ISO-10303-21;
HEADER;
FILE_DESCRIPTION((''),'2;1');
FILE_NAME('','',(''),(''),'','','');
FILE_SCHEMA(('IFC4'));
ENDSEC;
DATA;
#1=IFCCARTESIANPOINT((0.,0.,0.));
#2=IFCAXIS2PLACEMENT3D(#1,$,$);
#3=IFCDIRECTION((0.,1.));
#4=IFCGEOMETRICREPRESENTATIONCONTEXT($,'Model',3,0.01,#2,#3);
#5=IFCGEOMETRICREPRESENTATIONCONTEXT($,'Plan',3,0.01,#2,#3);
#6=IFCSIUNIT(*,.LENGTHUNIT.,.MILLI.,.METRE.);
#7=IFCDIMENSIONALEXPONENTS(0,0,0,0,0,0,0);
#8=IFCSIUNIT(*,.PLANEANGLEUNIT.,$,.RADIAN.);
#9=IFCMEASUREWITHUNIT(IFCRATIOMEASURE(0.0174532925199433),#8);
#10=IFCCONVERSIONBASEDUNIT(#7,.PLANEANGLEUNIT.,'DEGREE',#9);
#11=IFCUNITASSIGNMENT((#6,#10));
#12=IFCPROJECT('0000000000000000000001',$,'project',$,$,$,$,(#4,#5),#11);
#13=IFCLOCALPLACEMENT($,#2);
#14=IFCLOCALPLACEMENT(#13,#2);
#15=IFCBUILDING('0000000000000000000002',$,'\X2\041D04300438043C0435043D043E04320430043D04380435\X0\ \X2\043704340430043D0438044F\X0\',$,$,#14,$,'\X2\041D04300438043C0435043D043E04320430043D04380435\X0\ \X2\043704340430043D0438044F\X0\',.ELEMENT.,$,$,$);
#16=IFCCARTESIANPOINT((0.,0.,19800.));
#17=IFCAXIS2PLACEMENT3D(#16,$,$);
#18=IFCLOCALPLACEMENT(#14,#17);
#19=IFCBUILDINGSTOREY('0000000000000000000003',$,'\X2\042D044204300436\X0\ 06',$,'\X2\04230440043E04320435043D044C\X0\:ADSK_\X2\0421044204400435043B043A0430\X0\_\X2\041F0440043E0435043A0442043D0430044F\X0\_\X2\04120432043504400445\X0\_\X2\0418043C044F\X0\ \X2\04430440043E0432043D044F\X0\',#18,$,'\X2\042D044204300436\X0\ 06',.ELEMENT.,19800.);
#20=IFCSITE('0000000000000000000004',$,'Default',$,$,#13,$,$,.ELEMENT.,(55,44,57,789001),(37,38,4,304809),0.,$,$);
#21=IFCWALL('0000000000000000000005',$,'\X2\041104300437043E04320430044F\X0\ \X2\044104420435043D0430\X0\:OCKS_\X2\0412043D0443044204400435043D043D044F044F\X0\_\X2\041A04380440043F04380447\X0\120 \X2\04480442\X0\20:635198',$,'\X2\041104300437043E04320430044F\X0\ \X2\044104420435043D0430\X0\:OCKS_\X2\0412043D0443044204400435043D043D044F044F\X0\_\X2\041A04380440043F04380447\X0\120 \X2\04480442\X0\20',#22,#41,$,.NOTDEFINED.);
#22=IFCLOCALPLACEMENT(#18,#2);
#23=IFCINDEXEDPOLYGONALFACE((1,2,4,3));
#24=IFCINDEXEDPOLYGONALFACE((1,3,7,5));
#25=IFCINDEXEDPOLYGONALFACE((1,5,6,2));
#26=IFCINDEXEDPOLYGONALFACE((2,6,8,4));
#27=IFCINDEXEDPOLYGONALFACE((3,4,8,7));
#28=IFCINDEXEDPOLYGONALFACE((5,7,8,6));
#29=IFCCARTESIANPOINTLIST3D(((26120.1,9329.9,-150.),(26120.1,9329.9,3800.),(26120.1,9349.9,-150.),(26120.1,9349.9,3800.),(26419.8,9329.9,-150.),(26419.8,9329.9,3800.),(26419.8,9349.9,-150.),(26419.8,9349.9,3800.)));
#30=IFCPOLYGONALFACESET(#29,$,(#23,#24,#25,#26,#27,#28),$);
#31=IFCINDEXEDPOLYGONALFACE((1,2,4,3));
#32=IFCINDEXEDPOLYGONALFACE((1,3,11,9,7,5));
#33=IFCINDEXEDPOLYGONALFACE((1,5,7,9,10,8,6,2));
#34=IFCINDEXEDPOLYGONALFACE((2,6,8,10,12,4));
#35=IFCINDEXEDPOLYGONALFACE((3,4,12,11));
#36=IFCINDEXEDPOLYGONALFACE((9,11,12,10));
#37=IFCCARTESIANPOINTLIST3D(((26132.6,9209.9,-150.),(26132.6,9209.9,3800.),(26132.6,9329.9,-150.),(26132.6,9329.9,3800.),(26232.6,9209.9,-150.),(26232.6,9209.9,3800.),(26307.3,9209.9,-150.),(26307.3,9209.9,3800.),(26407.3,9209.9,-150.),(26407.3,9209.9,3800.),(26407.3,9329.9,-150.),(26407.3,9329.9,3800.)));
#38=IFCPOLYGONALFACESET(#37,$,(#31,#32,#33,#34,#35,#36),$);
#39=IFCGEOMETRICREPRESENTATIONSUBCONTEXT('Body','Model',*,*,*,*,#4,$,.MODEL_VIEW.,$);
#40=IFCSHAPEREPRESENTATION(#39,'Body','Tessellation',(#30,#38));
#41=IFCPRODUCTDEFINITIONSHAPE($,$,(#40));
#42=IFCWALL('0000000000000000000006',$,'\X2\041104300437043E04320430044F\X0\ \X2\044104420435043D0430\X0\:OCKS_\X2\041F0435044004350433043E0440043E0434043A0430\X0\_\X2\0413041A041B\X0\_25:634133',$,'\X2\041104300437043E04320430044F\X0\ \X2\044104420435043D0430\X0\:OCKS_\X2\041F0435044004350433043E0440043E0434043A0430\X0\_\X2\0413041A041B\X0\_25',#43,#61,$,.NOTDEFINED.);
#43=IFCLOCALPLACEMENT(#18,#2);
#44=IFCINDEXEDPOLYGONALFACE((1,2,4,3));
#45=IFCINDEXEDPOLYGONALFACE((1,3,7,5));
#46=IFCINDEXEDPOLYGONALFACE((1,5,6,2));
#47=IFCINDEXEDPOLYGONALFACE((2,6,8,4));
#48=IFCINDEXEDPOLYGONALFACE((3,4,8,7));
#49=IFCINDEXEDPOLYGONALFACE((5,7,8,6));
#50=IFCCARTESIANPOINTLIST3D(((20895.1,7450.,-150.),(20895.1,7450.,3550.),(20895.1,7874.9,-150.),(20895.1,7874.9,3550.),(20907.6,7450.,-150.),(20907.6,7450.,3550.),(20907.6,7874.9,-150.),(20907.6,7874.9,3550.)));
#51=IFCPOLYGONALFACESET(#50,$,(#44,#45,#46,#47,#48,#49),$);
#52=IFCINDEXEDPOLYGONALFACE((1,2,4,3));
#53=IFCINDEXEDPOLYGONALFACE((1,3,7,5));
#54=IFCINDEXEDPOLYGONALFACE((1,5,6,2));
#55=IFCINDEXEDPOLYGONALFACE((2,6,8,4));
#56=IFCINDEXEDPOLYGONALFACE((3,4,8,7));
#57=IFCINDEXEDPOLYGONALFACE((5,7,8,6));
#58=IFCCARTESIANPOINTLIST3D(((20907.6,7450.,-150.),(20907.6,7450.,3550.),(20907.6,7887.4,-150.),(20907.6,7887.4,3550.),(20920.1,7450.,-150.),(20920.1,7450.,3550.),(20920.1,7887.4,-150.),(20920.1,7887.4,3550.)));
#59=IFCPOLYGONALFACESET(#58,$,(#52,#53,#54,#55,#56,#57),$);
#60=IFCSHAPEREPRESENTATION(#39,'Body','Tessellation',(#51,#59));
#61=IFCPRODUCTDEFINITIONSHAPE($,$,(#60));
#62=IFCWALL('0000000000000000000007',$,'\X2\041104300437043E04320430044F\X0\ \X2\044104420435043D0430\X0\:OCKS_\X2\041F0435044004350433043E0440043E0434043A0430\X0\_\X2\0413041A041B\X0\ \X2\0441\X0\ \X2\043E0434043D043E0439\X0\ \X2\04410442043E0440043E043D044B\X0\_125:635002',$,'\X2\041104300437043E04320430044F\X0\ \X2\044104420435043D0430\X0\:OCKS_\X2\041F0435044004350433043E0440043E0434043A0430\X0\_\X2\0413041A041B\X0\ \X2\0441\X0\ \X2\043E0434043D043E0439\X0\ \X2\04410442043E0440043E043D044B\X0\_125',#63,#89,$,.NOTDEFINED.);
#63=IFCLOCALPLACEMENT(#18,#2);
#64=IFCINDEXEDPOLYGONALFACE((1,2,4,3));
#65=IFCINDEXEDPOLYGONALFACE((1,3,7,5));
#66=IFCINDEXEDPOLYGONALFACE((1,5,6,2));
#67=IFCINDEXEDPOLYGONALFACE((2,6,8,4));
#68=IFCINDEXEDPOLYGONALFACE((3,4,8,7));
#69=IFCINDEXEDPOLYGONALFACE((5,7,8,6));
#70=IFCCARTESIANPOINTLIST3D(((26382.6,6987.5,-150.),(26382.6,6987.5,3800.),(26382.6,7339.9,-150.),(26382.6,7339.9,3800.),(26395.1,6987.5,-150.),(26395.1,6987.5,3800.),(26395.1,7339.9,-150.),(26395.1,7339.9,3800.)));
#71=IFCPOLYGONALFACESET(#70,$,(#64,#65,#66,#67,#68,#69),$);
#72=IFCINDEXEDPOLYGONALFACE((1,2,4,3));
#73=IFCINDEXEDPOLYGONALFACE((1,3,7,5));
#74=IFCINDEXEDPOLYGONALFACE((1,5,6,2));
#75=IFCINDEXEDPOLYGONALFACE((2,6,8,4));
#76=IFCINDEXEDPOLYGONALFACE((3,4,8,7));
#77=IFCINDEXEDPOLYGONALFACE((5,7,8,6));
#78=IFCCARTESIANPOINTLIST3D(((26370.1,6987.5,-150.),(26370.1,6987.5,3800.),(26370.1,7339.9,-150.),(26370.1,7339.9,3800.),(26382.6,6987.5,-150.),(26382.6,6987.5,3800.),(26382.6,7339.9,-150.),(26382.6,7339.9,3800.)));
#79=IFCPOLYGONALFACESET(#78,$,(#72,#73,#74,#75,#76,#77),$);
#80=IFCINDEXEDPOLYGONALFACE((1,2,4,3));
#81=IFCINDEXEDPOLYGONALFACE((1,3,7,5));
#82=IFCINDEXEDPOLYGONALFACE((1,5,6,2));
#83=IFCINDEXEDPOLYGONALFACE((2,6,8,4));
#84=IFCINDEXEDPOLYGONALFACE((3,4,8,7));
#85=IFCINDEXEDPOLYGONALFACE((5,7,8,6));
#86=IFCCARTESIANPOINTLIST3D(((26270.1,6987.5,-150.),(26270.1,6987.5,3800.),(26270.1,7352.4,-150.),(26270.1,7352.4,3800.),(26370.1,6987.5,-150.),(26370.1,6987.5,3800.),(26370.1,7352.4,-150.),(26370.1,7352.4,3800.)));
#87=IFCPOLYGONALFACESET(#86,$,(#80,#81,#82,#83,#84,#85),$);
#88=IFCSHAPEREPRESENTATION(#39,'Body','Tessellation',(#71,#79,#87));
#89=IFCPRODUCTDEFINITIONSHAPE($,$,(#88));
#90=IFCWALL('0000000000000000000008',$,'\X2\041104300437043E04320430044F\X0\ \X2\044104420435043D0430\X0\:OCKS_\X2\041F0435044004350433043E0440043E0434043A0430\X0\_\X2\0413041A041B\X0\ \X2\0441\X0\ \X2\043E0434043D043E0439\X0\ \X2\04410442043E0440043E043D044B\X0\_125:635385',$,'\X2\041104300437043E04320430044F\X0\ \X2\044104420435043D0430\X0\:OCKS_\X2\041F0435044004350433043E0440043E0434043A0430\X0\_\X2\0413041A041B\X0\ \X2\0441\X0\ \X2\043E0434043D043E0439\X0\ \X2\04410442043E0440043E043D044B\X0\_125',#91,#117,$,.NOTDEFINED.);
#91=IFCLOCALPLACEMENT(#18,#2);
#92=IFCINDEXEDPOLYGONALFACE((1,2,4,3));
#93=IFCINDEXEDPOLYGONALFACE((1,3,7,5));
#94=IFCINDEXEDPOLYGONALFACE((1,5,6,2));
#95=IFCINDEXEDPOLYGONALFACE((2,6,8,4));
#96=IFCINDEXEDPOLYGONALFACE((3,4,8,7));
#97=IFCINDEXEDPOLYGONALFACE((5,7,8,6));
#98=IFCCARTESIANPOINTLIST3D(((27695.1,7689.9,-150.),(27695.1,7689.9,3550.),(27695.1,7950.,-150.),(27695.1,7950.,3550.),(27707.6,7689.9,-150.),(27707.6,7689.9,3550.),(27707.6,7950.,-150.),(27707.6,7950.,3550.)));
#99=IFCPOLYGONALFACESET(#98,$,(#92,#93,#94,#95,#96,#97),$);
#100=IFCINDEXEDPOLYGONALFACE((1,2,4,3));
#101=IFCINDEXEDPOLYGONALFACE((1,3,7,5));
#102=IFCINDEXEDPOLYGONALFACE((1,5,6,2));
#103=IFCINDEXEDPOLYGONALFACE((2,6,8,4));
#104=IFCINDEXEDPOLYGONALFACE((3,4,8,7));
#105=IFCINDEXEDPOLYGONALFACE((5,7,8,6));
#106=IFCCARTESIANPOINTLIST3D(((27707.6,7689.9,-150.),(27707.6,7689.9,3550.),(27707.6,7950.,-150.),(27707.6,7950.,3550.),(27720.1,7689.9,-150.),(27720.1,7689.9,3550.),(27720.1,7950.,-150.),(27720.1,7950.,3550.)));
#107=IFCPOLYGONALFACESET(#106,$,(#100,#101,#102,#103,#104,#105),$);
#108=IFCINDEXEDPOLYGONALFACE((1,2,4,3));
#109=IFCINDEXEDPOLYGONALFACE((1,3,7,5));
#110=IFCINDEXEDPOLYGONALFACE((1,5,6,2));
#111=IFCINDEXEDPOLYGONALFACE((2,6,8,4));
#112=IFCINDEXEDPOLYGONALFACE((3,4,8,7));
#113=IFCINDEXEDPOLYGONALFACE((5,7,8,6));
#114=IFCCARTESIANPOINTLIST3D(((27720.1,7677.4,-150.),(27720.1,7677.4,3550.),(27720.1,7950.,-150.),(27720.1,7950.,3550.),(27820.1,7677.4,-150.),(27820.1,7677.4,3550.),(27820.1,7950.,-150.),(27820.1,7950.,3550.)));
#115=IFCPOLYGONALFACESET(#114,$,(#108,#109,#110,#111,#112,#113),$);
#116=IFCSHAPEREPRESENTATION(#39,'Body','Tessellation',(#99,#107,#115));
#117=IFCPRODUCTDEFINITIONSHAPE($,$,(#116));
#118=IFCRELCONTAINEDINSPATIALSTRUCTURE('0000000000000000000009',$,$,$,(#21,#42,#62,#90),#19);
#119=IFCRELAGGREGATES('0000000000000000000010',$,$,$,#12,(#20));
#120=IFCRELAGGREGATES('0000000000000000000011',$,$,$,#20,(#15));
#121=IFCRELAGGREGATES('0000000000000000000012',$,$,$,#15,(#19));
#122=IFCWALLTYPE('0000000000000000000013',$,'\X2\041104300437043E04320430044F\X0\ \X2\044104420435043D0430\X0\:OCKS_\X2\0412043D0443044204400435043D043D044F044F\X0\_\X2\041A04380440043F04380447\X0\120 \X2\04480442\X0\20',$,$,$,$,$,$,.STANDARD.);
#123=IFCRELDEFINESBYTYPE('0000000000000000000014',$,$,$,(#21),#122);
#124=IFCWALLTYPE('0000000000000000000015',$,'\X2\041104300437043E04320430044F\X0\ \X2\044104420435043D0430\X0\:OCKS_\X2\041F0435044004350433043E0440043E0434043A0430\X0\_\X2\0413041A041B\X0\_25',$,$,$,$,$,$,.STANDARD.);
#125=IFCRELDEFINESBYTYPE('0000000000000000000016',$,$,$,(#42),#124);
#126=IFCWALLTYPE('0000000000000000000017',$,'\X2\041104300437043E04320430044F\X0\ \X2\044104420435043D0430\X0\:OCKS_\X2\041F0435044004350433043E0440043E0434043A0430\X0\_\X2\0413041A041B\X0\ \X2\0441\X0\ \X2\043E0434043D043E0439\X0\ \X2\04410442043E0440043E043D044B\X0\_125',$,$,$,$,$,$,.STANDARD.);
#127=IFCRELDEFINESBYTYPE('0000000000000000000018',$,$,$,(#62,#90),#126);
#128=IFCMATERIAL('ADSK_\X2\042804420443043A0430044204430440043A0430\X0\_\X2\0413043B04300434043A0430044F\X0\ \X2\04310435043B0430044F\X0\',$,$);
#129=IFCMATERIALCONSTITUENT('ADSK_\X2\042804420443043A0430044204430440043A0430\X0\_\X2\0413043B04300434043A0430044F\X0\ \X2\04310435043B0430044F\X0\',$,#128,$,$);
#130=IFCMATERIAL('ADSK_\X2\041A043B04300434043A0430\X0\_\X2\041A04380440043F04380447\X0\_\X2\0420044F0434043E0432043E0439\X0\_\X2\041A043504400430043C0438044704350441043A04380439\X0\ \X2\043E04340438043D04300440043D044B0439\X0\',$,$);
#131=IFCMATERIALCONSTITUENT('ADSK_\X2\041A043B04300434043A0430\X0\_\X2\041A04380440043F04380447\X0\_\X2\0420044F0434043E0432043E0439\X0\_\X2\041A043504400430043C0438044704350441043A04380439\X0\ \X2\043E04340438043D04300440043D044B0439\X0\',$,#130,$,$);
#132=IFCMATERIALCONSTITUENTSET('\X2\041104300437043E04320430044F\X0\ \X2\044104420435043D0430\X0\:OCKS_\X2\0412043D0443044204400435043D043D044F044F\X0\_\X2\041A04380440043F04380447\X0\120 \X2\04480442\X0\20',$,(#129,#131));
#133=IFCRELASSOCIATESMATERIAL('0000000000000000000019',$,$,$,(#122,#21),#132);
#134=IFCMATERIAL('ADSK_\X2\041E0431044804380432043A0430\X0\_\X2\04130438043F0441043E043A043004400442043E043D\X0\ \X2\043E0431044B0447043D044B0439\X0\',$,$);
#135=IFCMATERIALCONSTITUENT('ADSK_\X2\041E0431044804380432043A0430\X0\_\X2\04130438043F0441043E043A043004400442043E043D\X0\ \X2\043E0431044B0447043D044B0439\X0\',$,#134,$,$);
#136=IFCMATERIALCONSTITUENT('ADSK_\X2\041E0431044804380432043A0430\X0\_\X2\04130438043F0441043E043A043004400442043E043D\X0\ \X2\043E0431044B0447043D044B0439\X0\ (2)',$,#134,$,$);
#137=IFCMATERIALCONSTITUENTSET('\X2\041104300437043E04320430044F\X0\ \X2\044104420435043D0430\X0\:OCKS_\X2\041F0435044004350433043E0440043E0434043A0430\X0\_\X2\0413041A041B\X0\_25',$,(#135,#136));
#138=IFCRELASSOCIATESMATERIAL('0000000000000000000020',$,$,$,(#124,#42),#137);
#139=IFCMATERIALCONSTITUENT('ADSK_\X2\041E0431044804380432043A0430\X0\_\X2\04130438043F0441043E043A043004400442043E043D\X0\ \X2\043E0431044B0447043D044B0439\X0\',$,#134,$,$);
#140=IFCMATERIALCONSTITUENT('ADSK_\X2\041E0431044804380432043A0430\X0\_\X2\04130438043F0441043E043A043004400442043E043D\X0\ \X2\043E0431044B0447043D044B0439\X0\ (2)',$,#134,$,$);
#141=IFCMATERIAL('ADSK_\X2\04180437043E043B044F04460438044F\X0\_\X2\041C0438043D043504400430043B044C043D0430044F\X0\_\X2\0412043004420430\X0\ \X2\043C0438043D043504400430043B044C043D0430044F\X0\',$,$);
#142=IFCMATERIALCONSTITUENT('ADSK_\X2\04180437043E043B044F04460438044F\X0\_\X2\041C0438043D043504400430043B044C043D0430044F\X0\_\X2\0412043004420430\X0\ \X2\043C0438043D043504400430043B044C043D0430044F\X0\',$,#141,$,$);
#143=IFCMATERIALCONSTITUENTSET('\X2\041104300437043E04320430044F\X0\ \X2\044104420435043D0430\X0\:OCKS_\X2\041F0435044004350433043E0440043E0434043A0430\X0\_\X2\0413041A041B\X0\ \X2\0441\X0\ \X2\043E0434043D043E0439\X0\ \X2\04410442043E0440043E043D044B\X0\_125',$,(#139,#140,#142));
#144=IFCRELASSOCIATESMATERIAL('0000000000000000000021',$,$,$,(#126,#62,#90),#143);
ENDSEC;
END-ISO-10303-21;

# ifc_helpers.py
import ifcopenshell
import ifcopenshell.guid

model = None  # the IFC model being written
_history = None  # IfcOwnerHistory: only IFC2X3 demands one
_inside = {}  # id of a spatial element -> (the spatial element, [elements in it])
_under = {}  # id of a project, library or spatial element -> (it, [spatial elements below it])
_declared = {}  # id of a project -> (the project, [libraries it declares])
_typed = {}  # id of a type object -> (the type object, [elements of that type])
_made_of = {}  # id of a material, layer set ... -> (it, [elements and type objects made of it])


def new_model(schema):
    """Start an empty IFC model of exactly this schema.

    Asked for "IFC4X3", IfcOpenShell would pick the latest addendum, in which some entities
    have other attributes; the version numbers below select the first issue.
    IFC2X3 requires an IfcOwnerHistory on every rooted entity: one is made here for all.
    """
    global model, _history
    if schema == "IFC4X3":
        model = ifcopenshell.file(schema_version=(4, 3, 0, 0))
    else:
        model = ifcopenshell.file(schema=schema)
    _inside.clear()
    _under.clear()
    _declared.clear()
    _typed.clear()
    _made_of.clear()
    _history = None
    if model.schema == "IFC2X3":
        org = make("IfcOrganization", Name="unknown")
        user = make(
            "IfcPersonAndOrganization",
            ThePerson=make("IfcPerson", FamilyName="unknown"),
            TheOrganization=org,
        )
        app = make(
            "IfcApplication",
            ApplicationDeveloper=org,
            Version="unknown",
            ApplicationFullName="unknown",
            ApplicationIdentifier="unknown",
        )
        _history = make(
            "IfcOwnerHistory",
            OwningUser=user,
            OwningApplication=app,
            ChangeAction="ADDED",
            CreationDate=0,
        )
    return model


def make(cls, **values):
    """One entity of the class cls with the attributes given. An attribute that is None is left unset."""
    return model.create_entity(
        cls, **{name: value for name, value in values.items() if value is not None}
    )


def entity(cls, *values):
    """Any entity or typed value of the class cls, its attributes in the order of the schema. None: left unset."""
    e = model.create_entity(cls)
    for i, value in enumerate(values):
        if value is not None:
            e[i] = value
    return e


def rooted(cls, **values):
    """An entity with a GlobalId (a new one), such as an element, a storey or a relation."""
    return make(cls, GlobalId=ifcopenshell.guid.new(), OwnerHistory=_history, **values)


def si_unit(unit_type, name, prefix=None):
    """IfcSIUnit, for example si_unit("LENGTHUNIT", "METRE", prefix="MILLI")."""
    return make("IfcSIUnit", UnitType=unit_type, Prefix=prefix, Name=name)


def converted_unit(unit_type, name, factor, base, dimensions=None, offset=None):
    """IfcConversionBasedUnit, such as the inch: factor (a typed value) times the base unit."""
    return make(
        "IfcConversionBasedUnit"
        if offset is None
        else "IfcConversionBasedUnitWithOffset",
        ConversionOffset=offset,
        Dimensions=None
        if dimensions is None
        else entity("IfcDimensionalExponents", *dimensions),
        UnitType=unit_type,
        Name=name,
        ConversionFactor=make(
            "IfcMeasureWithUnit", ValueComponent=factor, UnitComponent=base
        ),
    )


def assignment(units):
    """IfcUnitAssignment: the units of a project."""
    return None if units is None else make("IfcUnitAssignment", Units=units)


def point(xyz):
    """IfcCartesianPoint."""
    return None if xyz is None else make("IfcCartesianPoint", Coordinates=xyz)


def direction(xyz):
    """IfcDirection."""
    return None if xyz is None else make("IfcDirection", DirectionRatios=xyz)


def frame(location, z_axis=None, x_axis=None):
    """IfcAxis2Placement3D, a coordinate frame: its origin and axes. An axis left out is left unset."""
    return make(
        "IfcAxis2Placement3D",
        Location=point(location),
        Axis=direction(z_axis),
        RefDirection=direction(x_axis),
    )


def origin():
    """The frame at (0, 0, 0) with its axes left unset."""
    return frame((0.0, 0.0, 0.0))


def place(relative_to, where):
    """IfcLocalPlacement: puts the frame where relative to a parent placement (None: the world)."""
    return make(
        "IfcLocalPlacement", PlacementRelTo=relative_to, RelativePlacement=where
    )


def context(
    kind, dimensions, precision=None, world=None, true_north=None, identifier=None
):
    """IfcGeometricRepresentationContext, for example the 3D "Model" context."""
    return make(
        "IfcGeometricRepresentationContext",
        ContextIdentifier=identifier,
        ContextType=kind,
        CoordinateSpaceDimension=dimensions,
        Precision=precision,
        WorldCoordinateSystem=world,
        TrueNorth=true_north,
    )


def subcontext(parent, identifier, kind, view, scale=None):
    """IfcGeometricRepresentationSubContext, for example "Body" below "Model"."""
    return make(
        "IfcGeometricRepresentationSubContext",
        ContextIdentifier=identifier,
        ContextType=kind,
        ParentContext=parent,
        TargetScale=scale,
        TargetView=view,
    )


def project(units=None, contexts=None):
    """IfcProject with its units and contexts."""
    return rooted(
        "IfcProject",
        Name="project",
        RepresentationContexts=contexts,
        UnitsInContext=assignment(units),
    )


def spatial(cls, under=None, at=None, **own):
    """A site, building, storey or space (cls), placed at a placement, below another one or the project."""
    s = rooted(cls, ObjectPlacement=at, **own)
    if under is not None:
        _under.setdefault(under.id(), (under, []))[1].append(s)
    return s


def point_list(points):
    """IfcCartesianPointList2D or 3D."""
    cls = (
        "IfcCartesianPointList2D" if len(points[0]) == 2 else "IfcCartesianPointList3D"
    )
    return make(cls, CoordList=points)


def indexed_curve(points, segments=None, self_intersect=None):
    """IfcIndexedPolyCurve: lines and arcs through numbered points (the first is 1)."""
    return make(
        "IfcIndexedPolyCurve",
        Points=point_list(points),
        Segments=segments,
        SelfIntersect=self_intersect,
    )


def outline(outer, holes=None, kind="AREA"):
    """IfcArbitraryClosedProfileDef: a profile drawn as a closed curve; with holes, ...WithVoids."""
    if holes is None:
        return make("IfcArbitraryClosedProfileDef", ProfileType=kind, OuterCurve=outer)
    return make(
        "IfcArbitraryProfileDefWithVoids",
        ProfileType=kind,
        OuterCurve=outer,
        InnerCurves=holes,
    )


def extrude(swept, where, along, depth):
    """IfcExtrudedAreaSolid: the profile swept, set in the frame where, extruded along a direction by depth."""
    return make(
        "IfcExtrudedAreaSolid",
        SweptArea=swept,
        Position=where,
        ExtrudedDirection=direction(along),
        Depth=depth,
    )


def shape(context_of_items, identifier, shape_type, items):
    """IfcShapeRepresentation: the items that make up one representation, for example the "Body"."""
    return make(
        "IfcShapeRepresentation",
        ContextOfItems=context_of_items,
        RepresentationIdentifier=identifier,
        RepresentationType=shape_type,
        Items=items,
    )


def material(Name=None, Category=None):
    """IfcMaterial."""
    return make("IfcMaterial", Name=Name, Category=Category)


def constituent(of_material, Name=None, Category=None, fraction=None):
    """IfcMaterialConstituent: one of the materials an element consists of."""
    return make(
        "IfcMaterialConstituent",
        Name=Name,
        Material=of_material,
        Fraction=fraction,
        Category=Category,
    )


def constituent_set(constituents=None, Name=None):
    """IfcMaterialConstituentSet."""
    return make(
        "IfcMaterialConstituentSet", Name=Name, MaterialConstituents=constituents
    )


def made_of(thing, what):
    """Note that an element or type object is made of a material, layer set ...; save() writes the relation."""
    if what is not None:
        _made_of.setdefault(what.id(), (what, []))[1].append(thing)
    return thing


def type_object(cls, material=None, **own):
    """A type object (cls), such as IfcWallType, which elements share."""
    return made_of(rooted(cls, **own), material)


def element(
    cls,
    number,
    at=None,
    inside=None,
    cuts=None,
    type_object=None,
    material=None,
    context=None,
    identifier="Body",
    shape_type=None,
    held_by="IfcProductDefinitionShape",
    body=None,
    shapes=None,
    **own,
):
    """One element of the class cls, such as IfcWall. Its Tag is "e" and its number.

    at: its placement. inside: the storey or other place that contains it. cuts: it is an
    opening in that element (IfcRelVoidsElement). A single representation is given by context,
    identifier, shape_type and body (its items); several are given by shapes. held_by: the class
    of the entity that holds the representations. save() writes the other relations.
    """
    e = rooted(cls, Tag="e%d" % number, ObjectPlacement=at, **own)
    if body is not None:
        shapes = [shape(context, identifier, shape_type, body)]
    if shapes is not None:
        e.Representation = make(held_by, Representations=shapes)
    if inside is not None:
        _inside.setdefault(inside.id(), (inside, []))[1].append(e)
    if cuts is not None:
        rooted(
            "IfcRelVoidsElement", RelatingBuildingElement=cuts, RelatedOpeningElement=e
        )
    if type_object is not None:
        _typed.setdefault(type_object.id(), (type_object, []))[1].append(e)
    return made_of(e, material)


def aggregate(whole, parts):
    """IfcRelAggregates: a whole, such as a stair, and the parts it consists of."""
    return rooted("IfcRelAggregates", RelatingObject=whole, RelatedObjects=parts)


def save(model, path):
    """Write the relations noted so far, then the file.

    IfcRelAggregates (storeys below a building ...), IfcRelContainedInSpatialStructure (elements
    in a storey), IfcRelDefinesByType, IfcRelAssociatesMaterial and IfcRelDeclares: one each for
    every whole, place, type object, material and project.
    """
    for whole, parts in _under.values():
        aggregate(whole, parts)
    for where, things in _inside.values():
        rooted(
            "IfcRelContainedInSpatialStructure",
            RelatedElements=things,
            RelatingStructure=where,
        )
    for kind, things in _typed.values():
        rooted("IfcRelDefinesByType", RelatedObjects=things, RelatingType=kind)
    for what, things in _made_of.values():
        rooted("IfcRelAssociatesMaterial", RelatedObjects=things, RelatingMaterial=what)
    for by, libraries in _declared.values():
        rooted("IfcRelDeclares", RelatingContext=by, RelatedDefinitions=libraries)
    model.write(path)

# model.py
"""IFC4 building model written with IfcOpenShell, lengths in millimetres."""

from ifc_helpers import new_model, entity, si_unit, converted_unit, direction, frame, origin, place, context, subcontext, project, spatial, indexed_curve, outline, extrude, material, constituent, constituent_set, type_object, element, save


model = new_model("IFC4")

# Units and contexts
model_context = context("Model", 3, precision=0.01, world=origin(), true_north=direction((0.0, 1.0)))
plan_context = context("Plan", 3, precision=0.01, world=origin(), true_north=direction((0.0, 1.0)))
body_context = subcontext(model_context, "Body", "Model", "MODEL_VIEW")
ifc_project = project(units=[si_unit("LENGTHUNIT", "METRE", prefix="MILLI"), converted_unit("PLANEANGLEUNIT", "DEGREE", entity("IfcRatioMeasure", 0.0174532925199433), si_unit("PLANEANGLEUNIT", "RADIAN"), dimensions=[0, 0, 0, 0, 0, 0, 0])], contexts=[model_context, plan_context])

# Site, building, storey
site_placement = place(None, frame((0.0, 0.0, 0.0)))
site = spatial("IfcSite", under=ifc_project, at=site_placement, Name="Default", CompositionType="ELEMENT", RefLatitude=(55, 44, 57, 789001), RefLongitude=(37, 38, 4, 304809), RefElevation=0.0)
building_placement = place(site_placement, origin())
building = spatial("IfcBuilding", under=site, at=building_placement, Name="Наименование здания", LongName="Наименование здания", CompositionType="ELEMENT")
storey_placement = place(building_placement, frame((0.0, 0.0, 19800.0)))
storey = spatial("IfcBuildingStorey", under=building, at=storey_placement, Name="Этаж 06", ObjectType="Уровень:ADSK_Стрелка_Проектная_Вверх_Имя уровня", LongName="Этаж 06", CompositionType="ELEMENT", Elevation=19800.0)

# Shared definitions
ifc_material_1 = material(Name="ADSK_Обшивка_Гипсокартон обычный")
ifc_material_2 = material(Name="ADSK_Изоляция_Минеральная_Вата минеральная")

# Wall
ifc_material_3 = material(Name="ADSK_Штукатурка_Гладкая белая")
ifc_constituent_1 = constituent(ifc_material_3, Name="ADSK_Штукатурка_Гладкая белая")
ifc_material_4 = material(Name="ADSK_Кладка_Кирпич_Рядовой_Керамический одинарный")
ifc_constituent_2 = constituent(ifc_material_4, Name="ADSK_Кладка_Кирпич_Рядовой_Керамический одинарный")
ifc_constituent_set_1 = constituent_set(constituents=[ifc_constituent_1, ifc_constituent_2], Name="Базовая стена:OCKS_Внутренняя_Кирпич120 шт20")
wall_type_1 = type_object("IfcWallType", Name="Базовая стена:OCKS_Внутренняя_Кирпич120 шт20", PredefinedType="STANDARD", material=ifc_constituent_set_1)
wall_1_placement = place(storey_placement, frame((26120.1, 9279.9, -150.0)))
element("IfcWall", 1, at=wall_1_placement, inside=storey, type_object=wall_type_1, material=ifc_constituent_set_1, Name="Базовая стена:OCKS_Внутренняя_Кирпич120 шт20:635198", ObjectType="Базовая стена:OCKS_Внутренняя_Кирпич120 шт20", PredefinedType="NOTDEFINED", context=body_context, shape_type="SweptSolid", body=[
    extrude(outline(indexed_curve([(-10.0, -149.9), (10.0, -149.9), (10.0, 149.9), (-10.0, 149.9), (-10.0, -149.9)], self_intersect=False)), frame((149.9, 60.0, 0.0), z_axis=(0.0, 0.0, 1.0), x_axis=(0.0, -1.0, 0.0)), (0.0, 0.0, 1.0), 3950.0),
    extrude(outline(indexed_curve([(-37.4, -40.0), (37.4, -40.0), (137.4, -40.0), (137.4, 80.0), (-137.4, 80.0), (-137.4, -40.0), (-37.4, -40.0)], self_intersect=False)), frame((149.9, -30.0, 0.0)), (0.0, 0.0, 1.0), 3950.0),
])

# Walls
ifc_constituent_3 = constituent(ifc_material_1, Name="ADSK_Обшивка_Гипсокартон обычный")
ifc_constituent_4 = constituent(ifc_material_1, Name="ADSK_Обшивка_Гипсокартон обычный (2)")
ifc_constituent_set_2 = constituent_set(constituents=[ifc_constituent_3, ifc_constituent_4], Name="Базовая стена:OCKS_Перегородка_ГКЛ_25")
wall_type_2 = type_object("IfcWallType", Name="Базовая стена:OCKS_Перегородка_ГКЛ_25", PredefinedType="STANDARD", material=ifc_constituent_set_2)
wall_2_placement = place(storey_placement, frame((20907.6, 7450.0, -150.0), z_axis=(0.0, 0.0, 1.0), x_axis=(0.0, 1.0, 0.0)))
element("IfcWall", 2, at=wall_2_placement, inside=storey, type_object=wall_type_2, material=ifc_constituent_set_2, Name="Базовая стена:OCKS_Перегородка_ГКЛ_25:634133", ObjectType="Базовая стена:OCKS_Перегородка_ГКЛ_25", PredefinedType="NOTDEFINED", context=body_context, shape_type="SweptSolid", body=[
    extrude(outline(indexed_curve([(-6.2, -212.5), (6.3, -212.5), (6.3, 212.5), (-6.2, 212.5), (-6.2, -212.5)], self_intersect=False)), frame((212.5, 6.3, 0.0), z_axis=(0.0, 0.0, 1.0), x_axis=(0.0, -1.0, 0.0)), (0.0, 0.0, 1.0), 3700.0),
    extrude(outline(indexed_curve([(-6.2, -218.7), (6.2, -218.7), (6.2, 218.7), (-6.2, 218.7), (-6.2, -218.7)], self_intersect=False)), frame((218.7, -6.2, 0.0), z_axis=(0.0, 0.0, 1.0), x_axis=(0.0, 1.0, 0.0)), (0.0, 0.0, 1.0), 3700.0),
])
ifc_constituent_5 = constituent(ifc_material_1, Name="ADSK_Обшивка_Гипсокартон обычный")
ifc_constituent_6 = constituent(ifc_material_1, Name="ADSK_Обшивка_Гипсокартон обычный (2)")
ifc_constituent_7 = constituent(ifc_material_2, Name="ADSK_Изоляция_Минеральная_Вата минеральная")
ifc_constituent_set_3 = constituent_set(constituents=[ifc_constituent_5, ifc_constituent_6, ifc_constituent_7], Name="Базовая стена:OCKS_Перегородка_ГКЛ с одной стороны_125")
wall_type_3 = type_object("IfcWallType", Name="Базовая стена:OCKS_Перегородка_ГКЛ с одной стороны_125", PredefinedType="STANDARD", material=ifc_constituent_set_3)
wall_3_placement = place(storey_placement, frame((26332.6, 6987.5, -150.0), z_axis=(0.0, 0.0, 1.0), x_axis=(0.0, 1.0, 0.0)))
element("IfcWall", 3, at=wall_3_placement, inside=storey, type_object=wall_type_3, material=ifc_constituent_set_3, Name="Базовая стена:OCKS_Перегородка_ГКЛ с одной стороны_125:635002", ObjectType="Базовая стена:OCKS_Перегородка_ГКЛ с одной стороны_125", PredefinedType="NOTDEFINED", context=body_context, shape_type="SweptSolid", body=[
    extrude(outline(indexed_curve([(-6.2, -176.2), (6.3, -176.2), (6.3, 176.2), (-6.2, 176.2), (-6.2, -176.2)], self_intersect=False)), frame((176.2, -56.3, 0.0), z_axis=(0.0, 0.0, 1.0), x_axis=(0.0, 1.0, 0.0)), (0.0, 0.0, 1.0), 3950.0),
    extrude(outline(indexed_curve([(-176.2, -6.3), (176.2, -6.3), (176.2, 6.2), (-176.2, 6.2), (-176.2, -6.3)], self_intersect=False)), frame((176.2, -43.7, 0.0)), (0.0, 0.0, 1.0), 3950.0),
    extrude(outline(indexed_curve([(-50.0, -182.5), (50.0, -182.5), (50.0, 182.5), (-50.0, 182.5), (-50.0, -182.5)], self_intersect=False)), frame((182.5, 12.5, 0.0), z_axis=(0.0, 0.0, 1.0), x_axis=(0.0, -1.0, 0.0)), (0.0, 0.0, 1.0), 3950.0),
])
wall_4_placement = place(storey_placement, frame((27757.6, 7950.0, -150.0), z_axis=(0.0, 0.0, 1.0), x_axis=(0.0, -1.0, 0.0)))
element("IfcWall", 4, at=wall_4_placement, inside=storey, type_object=wall_type_3, material=ifc_constituent_set_3, Name="Базовая стена:OCKS_Перегородка_ГКЛ с одной стороны_125:635385", ObjectType="Базовая стена:OCKS_Перегородка_ГКЛ с одной стороны_125", PredefinedType="NOTDEFINED", context=body_context, shape_type="SweptSolid", body=[
    extrude(outline(indexed_curve([(-6.2, -130.0), (6.3, -130.0), (6.2, 130.0), (-6.3, 130.0), (-6.2, -130.0)], self_intersect=False)), frame((130.0, -56.3, 0.0), z_axis=(0.0, 0.0, 1.0), x_axis=(0.0, 1.0, 0.0)), (0.0, 0.0, 1.0), 3700.0),
    extrude(outline(indexed_curve([(-130.0, -6.3), (130.0, -6.3), (130.0, 6.2), (-130.0, 6.2), (-130.0, -6.3)], self_intersect=False)), frame((130.0, -43.7, 0.0)), (0.0, 0.0, 1.0), 3700.0),
    extrude(outline(indexed_curve([(-50.0, -136.3), (50.0, -136.3), (50.0, 136.3), (-50.0, 136.3), (-50.0, -136.3)], self_intersect=False)), frame((136.3, 12.5, 0.0), z_axis=(0.0, 0.0, 1.0), x_axis=(0.0, -1.0, 0.0)), (0.0, 0.0, 1.0), 3700.0),
])

save(model, "model.ifc")
